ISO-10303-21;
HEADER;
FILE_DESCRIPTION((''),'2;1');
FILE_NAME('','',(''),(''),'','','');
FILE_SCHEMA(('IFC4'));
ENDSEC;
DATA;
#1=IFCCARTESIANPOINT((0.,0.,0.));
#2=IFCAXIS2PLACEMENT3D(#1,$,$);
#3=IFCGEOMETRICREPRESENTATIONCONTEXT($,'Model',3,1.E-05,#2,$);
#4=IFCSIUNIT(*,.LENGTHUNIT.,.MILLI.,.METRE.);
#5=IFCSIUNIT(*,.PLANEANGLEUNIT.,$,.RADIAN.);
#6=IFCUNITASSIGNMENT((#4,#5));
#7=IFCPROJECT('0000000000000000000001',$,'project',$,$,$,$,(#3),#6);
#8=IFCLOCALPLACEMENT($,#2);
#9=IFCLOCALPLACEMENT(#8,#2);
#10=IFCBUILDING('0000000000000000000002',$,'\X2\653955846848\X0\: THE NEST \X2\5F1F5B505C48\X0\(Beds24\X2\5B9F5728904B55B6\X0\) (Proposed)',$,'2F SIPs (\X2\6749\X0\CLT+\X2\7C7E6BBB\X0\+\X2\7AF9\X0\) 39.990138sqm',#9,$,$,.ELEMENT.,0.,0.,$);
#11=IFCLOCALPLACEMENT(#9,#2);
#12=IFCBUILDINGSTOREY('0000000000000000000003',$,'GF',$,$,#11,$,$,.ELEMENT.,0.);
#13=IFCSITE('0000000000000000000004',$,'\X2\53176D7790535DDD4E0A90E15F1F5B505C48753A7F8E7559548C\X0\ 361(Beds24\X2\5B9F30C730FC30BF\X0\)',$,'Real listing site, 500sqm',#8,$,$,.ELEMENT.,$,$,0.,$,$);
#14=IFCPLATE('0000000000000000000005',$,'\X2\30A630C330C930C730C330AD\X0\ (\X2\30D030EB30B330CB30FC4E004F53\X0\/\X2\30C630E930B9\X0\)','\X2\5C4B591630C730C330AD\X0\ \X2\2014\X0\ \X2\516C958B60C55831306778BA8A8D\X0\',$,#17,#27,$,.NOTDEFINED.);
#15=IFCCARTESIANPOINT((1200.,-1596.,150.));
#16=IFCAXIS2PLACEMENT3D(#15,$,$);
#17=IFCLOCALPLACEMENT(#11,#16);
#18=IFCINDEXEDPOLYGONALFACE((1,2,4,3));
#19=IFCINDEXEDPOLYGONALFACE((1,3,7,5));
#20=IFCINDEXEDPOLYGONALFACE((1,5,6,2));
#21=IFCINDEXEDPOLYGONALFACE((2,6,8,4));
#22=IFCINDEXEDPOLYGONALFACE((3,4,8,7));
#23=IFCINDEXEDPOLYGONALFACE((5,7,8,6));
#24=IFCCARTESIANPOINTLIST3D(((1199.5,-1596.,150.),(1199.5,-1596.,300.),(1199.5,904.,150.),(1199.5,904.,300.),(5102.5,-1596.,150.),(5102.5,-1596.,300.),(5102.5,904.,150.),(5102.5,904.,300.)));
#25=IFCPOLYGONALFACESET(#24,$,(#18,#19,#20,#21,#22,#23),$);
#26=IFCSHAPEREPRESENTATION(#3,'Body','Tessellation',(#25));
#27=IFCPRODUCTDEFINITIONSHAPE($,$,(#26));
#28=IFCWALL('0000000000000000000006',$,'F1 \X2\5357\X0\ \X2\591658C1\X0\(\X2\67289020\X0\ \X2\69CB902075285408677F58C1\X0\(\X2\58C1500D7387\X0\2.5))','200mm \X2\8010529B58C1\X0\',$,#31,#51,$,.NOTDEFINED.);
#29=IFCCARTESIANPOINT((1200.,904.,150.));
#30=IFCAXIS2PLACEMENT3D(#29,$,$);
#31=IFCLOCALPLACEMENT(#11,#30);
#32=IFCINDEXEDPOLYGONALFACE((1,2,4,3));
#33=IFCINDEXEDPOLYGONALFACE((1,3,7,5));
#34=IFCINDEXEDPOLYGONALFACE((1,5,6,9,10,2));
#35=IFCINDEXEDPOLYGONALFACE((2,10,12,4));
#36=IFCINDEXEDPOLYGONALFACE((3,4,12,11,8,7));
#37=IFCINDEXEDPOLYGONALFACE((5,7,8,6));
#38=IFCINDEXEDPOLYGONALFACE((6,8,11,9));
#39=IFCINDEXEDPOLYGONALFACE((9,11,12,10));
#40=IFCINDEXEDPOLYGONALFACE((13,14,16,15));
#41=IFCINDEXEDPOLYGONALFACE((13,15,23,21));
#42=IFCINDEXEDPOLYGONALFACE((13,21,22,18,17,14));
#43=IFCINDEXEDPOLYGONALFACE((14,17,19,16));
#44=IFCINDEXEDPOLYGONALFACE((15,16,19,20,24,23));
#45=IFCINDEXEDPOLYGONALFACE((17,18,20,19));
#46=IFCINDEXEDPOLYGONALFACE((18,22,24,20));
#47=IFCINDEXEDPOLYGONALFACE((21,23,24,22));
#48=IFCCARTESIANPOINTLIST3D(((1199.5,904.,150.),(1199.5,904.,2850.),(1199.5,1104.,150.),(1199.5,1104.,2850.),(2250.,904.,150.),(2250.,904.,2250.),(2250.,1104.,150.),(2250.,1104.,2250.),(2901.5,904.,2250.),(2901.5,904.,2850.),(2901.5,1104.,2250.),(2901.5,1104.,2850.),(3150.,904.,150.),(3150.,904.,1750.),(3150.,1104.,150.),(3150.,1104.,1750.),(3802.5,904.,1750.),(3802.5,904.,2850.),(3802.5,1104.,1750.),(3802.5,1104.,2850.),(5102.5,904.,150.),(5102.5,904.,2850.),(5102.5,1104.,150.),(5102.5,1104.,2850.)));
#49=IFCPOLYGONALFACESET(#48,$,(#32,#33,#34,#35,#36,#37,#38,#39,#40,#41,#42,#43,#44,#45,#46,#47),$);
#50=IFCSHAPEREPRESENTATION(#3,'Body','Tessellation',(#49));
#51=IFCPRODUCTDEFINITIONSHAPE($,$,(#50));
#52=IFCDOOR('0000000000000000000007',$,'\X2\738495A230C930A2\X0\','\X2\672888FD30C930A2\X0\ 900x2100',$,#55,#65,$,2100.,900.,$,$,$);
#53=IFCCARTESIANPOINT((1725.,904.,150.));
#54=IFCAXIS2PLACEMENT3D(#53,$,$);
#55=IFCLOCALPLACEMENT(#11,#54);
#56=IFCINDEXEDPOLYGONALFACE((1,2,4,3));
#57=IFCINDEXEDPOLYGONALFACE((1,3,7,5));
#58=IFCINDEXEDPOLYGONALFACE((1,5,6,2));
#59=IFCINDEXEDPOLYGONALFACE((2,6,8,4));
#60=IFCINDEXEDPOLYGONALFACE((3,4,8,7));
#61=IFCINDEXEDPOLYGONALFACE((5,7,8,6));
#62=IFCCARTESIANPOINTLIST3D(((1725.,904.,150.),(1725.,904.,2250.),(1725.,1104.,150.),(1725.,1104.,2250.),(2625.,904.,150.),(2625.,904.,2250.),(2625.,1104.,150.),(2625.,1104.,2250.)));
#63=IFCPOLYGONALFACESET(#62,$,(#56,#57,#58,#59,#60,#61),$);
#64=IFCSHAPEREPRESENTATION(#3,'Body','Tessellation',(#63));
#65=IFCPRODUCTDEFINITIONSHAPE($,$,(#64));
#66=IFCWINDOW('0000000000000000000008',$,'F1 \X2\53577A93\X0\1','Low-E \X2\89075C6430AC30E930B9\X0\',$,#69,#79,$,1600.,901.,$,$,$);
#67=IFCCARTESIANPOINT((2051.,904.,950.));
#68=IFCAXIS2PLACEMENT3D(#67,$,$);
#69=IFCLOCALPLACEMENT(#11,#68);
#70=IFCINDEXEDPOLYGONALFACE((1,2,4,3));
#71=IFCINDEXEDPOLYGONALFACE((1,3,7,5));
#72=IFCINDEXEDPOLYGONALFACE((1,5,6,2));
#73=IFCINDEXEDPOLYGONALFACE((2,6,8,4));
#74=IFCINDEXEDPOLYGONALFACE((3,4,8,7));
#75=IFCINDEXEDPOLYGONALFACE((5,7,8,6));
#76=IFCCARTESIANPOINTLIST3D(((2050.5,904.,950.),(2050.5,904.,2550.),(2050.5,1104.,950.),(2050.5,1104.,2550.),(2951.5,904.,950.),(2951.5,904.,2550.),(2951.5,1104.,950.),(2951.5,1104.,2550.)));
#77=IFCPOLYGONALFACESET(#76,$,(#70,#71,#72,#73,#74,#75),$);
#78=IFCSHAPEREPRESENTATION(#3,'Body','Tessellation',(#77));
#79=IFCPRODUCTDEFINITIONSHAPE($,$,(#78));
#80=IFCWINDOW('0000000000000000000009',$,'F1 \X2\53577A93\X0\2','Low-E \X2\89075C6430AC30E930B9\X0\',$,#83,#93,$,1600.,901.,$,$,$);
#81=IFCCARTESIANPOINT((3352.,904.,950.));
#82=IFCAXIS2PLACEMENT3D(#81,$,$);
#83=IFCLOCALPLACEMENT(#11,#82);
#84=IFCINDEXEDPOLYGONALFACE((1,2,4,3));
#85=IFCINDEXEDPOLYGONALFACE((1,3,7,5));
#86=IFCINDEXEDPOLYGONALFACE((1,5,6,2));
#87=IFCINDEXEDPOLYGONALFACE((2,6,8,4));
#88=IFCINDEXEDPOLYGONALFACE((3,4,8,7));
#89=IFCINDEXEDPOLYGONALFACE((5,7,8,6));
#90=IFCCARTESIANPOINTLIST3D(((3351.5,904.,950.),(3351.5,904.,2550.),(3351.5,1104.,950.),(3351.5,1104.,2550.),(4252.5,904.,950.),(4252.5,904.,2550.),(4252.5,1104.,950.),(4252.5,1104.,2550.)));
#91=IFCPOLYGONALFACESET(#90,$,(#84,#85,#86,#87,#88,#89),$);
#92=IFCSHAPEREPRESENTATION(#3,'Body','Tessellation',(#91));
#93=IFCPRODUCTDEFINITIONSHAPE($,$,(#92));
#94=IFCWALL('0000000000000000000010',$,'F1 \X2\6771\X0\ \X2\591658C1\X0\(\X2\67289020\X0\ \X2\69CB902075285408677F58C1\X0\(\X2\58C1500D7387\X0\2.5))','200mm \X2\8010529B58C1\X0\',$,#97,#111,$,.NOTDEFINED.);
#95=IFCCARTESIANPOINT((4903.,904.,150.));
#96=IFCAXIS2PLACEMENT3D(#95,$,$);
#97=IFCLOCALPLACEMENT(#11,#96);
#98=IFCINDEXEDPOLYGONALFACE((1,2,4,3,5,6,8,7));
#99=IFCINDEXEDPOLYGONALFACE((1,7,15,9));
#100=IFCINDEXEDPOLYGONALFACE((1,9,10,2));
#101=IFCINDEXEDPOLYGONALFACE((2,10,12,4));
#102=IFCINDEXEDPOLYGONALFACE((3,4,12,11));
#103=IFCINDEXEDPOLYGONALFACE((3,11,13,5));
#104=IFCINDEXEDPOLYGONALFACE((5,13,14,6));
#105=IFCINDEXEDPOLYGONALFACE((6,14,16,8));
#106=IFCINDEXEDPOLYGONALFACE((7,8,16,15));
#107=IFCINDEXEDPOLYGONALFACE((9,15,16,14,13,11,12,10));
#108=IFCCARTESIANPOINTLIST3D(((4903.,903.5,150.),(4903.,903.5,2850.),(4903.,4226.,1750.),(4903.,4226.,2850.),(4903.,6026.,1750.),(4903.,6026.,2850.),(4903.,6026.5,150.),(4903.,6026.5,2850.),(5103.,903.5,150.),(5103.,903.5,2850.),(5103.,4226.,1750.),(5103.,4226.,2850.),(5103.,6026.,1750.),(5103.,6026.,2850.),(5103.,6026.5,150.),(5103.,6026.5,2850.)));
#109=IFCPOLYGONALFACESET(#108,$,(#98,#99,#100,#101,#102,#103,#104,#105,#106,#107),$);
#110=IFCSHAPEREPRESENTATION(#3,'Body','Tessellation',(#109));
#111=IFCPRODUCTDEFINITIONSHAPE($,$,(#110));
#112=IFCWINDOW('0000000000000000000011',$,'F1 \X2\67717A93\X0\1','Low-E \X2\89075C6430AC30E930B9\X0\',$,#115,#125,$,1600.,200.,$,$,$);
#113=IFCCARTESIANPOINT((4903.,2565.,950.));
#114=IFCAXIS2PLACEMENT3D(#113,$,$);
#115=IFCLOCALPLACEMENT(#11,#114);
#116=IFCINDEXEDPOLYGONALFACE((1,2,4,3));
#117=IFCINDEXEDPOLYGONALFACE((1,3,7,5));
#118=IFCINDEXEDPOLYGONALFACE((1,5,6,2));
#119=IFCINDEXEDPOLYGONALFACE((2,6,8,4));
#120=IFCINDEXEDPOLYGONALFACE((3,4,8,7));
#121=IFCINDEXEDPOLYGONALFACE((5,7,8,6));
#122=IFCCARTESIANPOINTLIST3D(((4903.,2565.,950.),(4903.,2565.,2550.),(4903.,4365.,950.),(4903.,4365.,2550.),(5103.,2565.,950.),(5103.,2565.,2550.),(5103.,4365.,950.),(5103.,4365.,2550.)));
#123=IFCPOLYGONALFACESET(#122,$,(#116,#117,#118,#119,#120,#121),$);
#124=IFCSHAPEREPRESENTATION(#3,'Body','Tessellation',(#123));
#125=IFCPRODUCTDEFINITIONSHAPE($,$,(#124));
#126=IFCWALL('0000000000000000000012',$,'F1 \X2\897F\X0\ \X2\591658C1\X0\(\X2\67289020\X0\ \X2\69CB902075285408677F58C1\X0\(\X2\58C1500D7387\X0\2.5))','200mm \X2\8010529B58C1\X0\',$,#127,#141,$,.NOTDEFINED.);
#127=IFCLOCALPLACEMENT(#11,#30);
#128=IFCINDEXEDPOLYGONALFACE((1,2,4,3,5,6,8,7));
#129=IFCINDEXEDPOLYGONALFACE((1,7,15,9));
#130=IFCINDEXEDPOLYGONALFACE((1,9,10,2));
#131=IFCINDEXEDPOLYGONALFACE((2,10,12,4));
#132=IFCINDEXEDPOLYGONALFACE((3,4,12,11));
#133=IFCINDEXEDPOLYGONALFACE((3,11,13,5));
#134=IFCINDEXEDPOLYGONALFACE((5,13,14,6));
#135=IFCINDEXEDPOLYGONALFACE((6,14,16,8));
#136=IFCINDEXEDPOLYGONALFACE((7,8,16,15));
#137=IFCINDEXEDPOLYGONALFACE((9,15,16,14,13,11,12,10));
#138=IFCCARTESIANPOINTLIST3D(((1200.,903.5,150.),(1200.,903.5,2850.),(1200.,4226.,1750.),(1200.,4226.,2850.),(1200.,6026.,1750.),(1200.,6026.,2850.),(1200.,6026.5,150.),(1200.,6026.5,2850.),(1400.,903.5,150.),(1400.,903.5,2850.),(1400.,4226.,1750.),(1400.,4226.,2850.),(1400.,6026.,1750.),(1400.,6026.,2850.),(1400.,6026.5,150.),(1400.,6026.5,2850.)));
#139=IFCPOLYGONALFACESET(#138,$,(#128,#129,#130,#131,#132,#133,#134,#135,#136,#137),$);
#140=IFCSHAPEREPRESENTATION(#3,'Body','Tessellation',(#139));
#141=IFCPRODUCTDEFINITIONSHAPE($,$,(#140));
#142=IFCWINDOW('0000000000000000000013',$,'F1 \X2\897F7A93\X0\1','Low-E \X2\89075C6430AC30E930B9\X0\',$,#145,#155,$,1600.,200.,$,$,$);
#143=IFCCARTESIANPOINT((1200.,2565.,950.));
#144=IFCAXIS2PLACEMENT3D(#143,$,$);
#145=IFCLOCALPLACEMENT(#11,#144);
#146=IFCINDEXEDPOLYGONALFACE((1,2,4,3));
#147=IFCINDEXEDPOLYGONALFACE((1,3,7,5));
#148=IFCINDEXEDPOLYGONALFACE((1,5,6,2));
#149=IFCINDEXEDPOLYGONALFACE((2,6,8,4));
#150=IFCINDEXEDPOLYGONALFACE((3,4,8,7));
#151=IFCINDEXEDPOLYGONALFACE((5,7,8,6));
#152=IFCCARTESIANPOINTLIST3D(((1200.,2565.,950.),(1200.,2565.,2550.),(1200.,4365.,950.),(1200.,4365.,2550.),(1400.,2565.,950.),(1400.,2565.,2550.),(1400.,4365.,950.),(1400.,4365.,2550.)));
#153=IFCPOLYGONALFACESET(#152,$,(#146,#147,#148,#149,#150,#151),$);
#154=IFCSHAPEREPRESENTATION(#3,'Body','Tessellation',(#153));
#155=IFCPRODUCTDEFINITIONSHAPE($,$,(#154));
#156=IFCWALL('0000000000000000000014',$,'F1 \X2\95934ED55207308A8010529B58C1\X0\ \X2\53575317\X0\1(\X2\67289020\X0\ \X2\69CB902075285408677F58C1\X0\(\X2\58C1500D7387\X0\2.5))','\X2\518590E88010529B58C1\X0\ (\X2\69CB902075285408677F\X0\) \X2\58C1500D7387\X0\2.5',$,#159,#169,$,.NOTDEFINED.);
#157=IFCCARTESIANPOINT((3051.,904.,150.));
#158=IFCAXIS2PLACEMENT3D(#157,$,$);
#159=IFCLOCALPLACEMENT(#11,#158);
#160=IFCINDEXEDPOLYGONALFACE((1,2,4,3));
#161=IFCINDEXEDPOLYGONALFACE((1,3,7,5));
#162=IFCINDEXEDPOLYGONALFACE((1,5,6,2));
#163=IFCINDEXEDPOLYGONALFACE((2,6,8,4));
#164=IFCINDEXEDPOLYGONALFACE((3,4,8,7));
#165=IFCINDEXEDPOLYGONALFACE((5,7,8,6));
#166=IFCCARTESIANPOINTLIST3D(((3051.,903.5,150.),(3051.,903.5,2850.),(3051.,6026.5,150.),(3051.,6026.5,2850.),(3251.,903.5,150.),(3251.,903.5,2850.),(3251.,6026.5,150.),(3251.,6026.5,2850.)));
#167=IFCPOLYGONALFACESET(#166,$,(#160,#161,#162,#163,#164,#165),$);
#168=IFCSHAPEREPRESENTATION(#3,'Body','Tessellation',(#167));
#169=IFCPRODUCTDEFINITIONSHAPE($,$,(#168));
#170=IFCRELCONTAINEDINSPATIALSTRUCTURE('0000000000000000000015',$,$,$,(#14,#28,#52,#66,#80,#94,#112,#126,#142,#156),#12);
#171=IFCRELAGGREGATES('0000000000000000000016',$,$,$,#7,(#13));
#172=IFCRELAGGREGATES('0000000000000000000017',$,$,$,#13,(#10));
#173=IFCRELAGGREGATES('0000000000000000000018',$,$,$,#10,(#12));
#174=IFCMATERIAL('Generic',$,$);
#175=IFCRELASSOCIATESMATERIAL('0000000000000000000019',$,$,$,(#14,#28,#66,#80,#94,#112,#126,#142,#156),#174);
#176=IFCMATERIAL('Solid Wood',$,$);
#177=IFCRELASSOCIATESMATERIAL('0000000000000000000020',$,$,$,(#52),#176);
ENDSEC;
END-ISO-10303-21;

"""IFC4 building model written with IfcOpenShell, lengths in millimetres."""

from ifc_helpers import new_model, si_unit, frame, frame_2d, origin, place, context, project, spatial, rectangle, extrude, material, element, fill, save


model = new_model("IFC4")

# Units and contexts
model_context = context("Model", 3, precision=1e-05, world=origin())
ifc_project = project(units=[si_unit("LENGTHUNIT", "METRE", prefix="MILLI"), si_unit("PLANEANGLEUNIT", "RADIAN")], contexts=[model_context])

# Site, building, storey
site_placement = place(None, origin())
site = spatial("IfcSite", under=ifc_project, at=site_placement, Name="北海道川上郡弟子屈町美留和 361(Beds24実データ)", ObjectType="Real listing site, 500sqm", CompositionType="ELEMENT", RefElevation=0.0)
building_placement = place(site_placement, origin())
building = spatial("IfcBuilding", under=site, at=building_placement, Name="改善案: THE NEST 弟子屈(Beds24実在運営) (Proposed)", ObjectType="2F SIPs (杉CLT+籾殻+竹) 39.990138sqm", CompositionType="ELEMENT", ElevationOfRefHeight=0.0, ElevationOfTerrain=0.0)
storey_placement = place(building_placement, origin())
storey = spatial("IfcBuildingStorey", under=building, at=storey_placement, Name="GF", CompositionType="ELEMENT", Elevation=0.0)

# Shared definitions
ifc_material_1 = material(Name="Generic")

# Plate
plate_placement = place(storey_placement, frame((1200.0, -1596.0, 150.0)))
element("IfcPlate", 1, at=plate_placement, inside=storey, material=ifc_material_1, Name="ウッドデッキ (バルコニー一体/テラス)", Description="屋外デッキ — 公開情報で確認", PredefinedType="NOTDEFINED", context=model_context, shape_type="SweptSolid", body=[
    extrude(rectangle(XDim=3903.0, YDim=2500.0, at=frame_2d((1951.0, 1250.0))), frame((1200.0, -1596.0, 150.0)), (0.0, 0.0, 1.0), 150.0),
])

# Wall, openings, door, windows
wall_1_placement = place(storey_placement, frame((1200.0, 904.0, 150.0)))
wall_1 = element("IfcWall", 2, at=wall_1_placement, inside=storey, material=ifc_material_1, Name="F1 南 外壁(木造 構造用合板壁(壁倍率2.5))", Description="200mm 耐力壁", PredefinedType="NOTDEFINED", context=model_context, shape_type="SweptSolid", body=[
    extrude(rectangle(XDim=3903.0, YDim=200.0, at=frame_2d((1951.0, 100.0))), frame((1200.0, 904.0, 150.0)), (0.0, 0.0, 1.0), 2700.0),
])
opening_1_placement = place(storey_placement, frame((1725.0, 904.0, 150.0)))
opening_1 = element("IfcOpeningElement", 3, at=opening_1_placement, cuts=wall_1, PredefinedType="NOTDEFINED", context=model_context, shape_type="SweptSolid", body=[
    extrude(rectangle(XDim=900.0, YDim=200.0, at=frame_2d((450.0, 100.0))), frame((1725.0, 904.0, 150.0)), (0.0, 0.0, 1.0), 2100.0),
])
opening_2_placement = place(storey_placement, frame((2051.0, 904.0, 950.0)))
opening_2 = element("IfcOpeningElement", 4, at=opening_2_placement, cuts=wall_1, PredefinedType="NOTDEFINED", context=model_context, shape_type="SweptSolid", body=[
    extrude(rectangle(XDim=901.0, YDim=200.0, at=frame_2d((450.0, 100.0))), frame((2051.0, 904.0, 950.0)), (0.0, 0.0, 1.0), 1600.0),
])
opening_3_placement = place(storey_placement, frame((3352.0, 904.0, 950.0)))
opening_3 = element("IfcOpeningElement", 5, at=opening_3_placement, cuts=wall_1, PredefinedType="NOTDEFINED", context=model_context, shape_type="SweptSolid", body=[
    extrude(rectangle(XDim=901.0, YDim=200.0, at=frame_2d((450.0, 100.0))), frame((3352.0, 904.0, 950.0)), (0.0, 0.0, 1.0), 1600.0),
])
ifc_material_2 = material(Name="Solid Wood")
door_placement = place(storey_placement, frame((1725.0, 904.0, 150.0)))
door = element("IfcDoor", 6, at=door_placement, inside=storey, material=ifc_material_2, Name="玄関ドア", Description="木製ドア 900x2100", OverallHeight=2100.0, OverallWidth=900.0, context=model_context, shape_type="SweptSolid", body=[
    extrude(rectangle(XDim=900.0, YDim=200.0, at=frame_2d((450.0, 100.0))), frame((1725.0, 904.0, 150.0)), (0.0, 0.0, 1.0), 2100.0),
])
fill(opening_1, door)
window_1_placement = place(storey_placement, frame((2051.0, 904.0, 950.0)))
window_1 = element("IfcWindow", 7, at=window_1_placement, inside=storey, material=ifc_material_1, Name="F1 南窓1", Description="Low-E 複層ガラス", OverallHeight=1600.0, OverallWidth=901.0, context=model_context, shape_type="SweptSolid", body=[
    extrude(rectangle(XDim=901.0, YDim=200.0, at=frame_2d((450.0, 100.0))), frame((2051.0, 904.0, 950.0)), (0.0, 0.0, 1.0), 1600.0),
])
fill(opening_2, window_1)
window_2_placement = place(storey_placement, frame((3352.0, 904.0, 950.0)))
window_2 = element("IfcWindow", 8, at=window_2_placement, inside=storey, material=ifc_material_1, Name="F1 南窓2", Description="Low-E 複層ガラス", OverallHeight=1600.0, OverallWidth=901.0, context=model_context, shape_type="SweptSolid", body=[
    extrude(rectangle(XDim=901.0, YDim=200.0, at=frame_2d((450.0, 100.0))), frame((3352.0, 904.0, 950.0)), (0.0, 0.0, 1.0), 1600.0),
])
fill(opening_3, window_2)

# Walls, openings, windows
wall_2_placement = place(storey_placement, frame((4903.0, 904.0, 150.0)))
wall_2 = element("IfcWall", 9, at=wall_2_placement, inside=storey, material=ifc_material_1, Name="F1 東 外壁(木造 構造用合板壁(壁倍率2.5))", Description="200mm 耐力壁", PredefinedType="NOTDEFINED", context=model_context, shape_type="SweptSolid", body=[
    extrude(rectangle(XDim=200.0, YDim=5123.0, at=frame_2d((100.0, 2561.0))), frame((4903.0, 904.0, 150.0)), (0.0, 0.0, 1.0), 2700.0),
])
opening_4_placement = place(storey_placement, frame((4903.0, 2565.0, 950.0)))
opening_4 = element("IfcOpeningElement", 10, at=opening_4_placement, cuts=wall_2, PredefinedType="NOTDEFINED", context=model_context, shape_type="SweptSolid", body=[
    extrude(rectangle(XDim=200.0, YDim=1800.0, at=frame_2d((100.0, 900.0))), frame((4903.0, 2565.0, 950.0)), (0.0, 0.0, 1.0), 1600.0),
])
window_3_placement = place(storey_placement, frame((4903.0, 2565.0, 950.0)))
window_3 = element("IfcWindow", 11, at=window_3_placement, inside=storey, material=ifc_material_1, Name="F1 東窓1", Description="Low-E 複層ガラス", OverallHeight=1600.0, OverallWidth=200.0, context=model_context, shape_type="SweptSolid", body=[
    extrude(rectangle(XDim=200.0, YDim=1800.0, at=frame_2d((100.0, 900.0))), frame((4903.0, 2565.0, 950.0)), (0.0, 0.0, 1.0), 1600.0),
])
fill(opening_4, window_3)
wall_3_placement = place(storey_placement, frame((1200.0, 904.0, 150.0)))
wall_3 = element("IfcWall", 12, at=wall_3_placement, inside=storey, material=ifc_material_1, Name="F1 西 外壁(木造 構造用合板壁(壁倍率2.5))", Description="200mm 耐力壁", PredefinedType="NOTDEFINED", context=model_context, shape_type="SweptSolid", body=[
    extrude(rectangle(XDim=200.0, YDim=5123.0, at=frame_2d((100.0, 2561.0))), frame((1200.0, 904.0, 150.0)), (0.0, 0.0, 1.0), 2700.0),
])
opening_5_placement = place(storey_placement, frame((1200.0, 2565.0, 950.0)))
opening_5 = element("IfcOpeningElement", 13, at=opening_5_placement, cuts=wall_3, PredefinedType="NOTDEFINED", context=model_context, shape_type="SweptSolid", body=[
    extrude(rectangle(XDim=200.0, YDim=1800.0, at=frame_2d((100.0, 900.0))), frame((1200.0, 2565.0, 950.0)), (0.0, 0.0, 1.0), 1600.0),
])
window_4_placement = place(storey_placement, frame((1200.0, 2565.0, 950.0)))
window_4 = element("IfcWindow", 14, at=window_4_placement, inside=storey, material=ifc_material_1, Name="F1 西窓1", Description="Low-E 複層ガラス", OverallHeight=1600.0, OverallWidth=200.0, context=model_context, shape_type="SweptSolid", body=[
    extrude(rectangle(XDim=200.0, YDim=1800.0, at=frame_2d((100.0, 900.0))), frame((1200.0, 2565.0, 950.0)), (0.0, 0.0, 1.0), 1600.0),
])
fill(opening_5, window_4)

# Wall
wall_4_placement = place(storey_placement, frame((3051.0, 904.0, 150.0)))
element("IfcWall", 15, at=wall_4_placement, inside=storey, material=ifc_material_1, Name="F1 間仕切り耐力壁 南北1(木造 構造用合板壁(壁倍率2.5))", Description="内部耐力壁 (構造用合板) 壁倍率2.5", PredefinedType="NOTDEFINED", context=model_context, shape_type="SweptSolid", body=[
    extrude(rectangle(XDim=200.0, YDim=5123.0, at=frame_2d((100.0, 2561.0))), frame((3051.0, 904.0, 150.0)), (0.0, 0.0, 1.0), 2700.0),
])

save(model, "model.ifc")
